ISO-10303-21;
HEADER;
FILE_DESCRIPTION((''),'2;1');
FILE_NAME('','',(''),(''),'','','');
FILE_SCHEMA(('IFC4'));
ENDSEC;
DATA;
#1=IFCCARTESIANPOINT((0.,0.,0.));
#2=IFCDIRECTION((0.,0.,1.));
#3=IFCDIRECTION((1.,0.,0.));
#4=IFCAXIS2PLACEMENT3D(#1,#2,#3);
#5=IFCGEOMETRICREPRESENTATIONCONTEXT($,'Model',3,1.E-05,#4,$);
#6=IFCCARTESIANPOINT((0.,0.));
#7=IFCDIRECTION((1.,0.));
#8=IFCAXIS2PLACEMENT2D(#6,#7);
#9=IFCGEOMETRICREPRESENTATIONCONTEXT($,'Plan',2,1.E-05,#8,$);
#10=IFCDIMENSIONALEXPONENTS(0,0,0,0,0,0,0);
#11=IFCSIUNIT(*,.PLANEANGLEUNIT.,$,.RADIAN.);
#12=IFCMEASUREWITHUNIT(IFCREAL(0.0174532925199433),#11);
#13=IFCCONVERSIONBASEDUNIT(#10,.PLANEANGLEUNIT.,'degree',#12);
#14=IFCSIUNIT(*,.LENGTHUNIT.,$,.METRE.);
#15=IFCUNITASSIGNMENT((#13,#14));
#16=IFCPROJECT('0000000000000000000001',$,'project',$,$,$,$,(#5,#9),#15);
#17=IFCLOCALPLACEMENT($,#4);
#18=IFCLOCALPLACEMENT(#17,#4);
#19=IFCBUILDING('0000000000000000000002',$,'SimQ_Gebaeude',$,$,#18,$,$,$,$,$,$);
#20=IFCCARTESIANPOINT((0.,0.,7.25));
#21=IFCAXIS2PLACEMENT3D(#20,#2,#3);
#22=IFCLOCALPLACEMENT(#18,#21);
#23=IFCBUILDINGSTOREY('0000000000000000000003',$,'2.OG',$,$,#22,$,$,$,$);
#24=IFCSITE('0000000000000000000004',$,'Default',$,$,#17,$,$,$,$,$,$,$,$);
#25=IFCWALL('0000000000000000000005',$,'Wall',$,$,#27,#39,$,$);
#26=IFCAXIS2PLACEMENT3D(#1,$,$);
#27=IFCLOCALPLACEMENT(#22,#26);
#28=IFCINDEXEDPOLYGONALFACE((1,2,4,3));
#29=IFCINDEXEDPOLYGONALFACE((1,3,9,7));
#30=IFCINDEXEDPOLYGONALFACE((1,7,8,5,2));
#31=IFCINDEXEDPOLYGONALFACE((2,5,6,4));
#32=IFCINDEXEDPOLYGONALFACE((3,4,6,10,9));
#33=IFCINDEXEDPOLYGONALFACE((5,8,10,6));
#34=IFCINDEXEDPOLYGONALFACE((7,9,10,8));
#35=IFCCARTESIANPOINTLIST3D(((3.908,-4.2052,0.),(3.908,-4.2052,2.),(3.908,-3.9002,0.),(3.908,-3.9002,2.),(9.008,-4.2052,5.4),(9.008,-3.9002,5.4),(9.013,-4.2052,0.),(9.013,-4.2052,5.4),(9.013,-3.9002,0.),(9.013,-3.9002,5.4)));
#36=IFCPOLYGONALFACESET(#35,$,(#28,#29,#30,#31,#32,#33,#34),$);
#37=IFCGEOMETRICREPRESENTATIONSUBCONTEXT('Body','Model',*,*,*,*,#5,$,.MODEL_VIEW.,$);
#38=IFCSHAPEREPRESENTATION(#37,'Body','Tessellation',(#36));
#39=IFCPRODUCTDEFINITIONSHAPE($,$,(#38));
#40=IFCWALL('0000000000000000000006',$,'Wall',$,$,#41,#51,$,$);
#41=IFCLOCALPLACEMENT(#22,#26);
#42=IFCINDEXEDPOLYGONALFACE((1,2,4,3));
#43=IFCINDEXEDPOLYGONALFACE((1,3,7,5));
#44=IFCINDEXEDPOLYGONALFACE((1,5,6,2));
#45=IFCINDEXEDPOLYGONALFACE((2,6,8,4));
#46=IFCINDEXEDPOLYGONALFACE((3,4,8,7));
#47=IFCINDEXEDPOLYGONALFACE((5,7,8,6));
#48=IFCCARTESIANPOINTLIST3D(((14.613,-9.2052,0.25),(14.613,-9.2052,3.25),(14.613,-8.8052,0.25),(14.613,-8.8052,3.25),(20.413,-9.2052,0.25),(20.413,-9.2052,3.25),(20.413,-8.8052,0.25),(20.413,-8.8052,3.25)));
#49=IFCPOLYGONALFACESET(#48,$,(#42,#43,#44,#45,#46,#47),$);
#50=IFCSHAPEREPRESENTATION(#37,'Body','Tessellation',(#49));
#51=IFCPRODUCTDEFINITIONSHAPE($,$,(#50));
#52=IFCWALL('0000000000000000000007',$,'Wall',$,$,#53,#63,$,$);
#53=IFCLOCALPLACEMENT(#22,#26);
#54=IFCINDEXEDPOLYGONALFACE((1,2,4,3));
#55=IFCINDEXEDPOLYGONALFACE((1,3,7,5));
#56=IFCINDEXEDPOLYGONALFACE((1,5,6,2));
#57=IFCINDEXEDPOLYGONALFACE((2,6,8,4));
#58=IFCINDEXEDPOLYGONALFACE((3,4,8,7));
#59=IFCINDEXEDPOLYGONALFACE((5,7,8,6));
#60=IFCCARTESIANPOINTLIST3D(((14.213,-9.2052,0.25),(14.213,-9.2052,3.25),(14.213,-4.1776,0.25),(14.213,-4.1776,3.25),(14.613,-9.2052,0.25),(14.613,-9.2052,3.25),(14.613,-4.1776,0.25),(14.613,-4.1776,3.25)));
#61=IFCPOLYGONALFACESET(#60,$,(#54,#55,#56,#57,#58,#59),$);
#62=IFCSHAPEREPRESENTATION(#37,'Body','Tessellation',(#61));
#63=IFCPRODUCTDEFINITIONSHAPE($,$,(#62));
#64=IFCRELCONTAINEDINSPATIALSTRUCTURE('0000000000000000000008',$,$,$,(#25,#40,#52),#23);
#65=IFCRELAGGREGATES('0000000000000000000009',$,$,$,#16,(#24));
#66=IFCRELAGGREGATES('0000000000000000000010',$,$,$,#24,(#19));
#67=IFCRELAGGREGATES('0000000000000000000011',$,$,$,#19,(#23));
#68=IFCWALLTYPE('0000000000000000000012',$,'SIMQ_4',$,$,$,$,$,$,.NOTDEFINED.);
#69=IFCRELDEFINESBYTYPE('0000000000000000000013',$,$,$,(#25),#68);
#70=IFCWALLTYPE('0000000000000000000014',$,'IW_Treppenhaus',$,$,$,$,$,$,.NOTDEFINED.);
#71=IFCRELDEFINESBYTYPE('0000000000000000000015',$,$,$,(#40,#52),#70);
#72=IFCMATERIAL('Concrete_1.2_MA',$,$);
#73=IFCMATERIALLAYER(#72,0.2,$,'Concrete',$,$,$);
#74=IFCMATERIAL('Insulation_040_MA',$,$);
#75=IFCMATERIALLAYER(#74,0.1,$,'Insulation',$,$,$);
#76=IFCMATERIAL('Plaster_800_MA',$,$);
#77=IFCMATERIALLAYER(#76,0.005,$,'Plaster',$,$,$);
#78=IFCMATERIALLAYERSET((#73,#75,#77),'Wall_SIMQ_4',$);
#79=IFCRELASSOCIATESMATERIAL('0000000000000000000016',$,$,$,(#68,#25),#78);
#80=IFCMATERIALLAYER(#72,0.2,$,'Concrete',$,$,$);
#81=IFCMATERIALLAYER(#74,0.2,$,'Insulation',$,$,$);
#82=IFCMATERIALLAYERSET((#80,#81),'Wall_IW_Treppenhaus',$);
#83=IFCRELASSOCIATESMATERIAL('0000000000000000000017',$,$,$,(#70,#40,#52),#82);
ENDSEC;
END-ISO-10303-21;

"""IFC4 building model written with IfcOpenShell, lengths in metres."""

from ifc_helpers import new_model, entity, si_unit, converted_unit, frame, origin_with_axes, origin_2d_with_axis, place, context, subcontext, project, spatial, indexed_curve, outline, extrude, clip, halfspace, material, layer, layer_set, layer_usage, type_object, element, save


model = new_model("IFC4")

# Units and contexts
model_context = context("Model", 3, precision=1e-05, world=origin_with_axes())
plan_context = context("Plan", 2, precision=1e-05, world=origin_2d_with_axis())
body_context = subcontext(model_context, "Body", "Model", "MODEL_VIEW")
ifc_project = project(units=[converted_unit("PLANEANGLEUNIT", "degree", entity("IfcReal", 0.0174532925199433), si_unit("PLANEANGLEUNIT", "RADIAN"), dimensions=[0, 0, 0, 0, 0, 0, 0]), si_unit("LENGTHUNIT", "METRE")], contexts=[model_context, plan_context])

# Site, building, storey
site_placement = place(None, origin_with_axes())
site = spatial("IfcSite", under=ifc_project, at=site_placement, Name="Default")
building_placement = place(site_placement, origin_with_axes())
building = spatial("IfcBuilding", under=site, at=building_placement, Name="SimQ_Gebaeude")
storey_placement = place(building_placement, frame((0.0, 0.0, 7.25), z_axis=(0.0, 0.0, 1.0), x_axis=(1.0, 0.0, 0.0)))
storey = spatial("IfcBuildingStorey", under=building, at=storey_placement, Name="2.OG")

# Shared definitions
ifc_material_1 = material(Name="Insulation_040_MA")
ifc_material_2 = material(Name="Concrete_1.2_MA")

# Shared definitions
ifc_layer_1 = layer(ifc_material_2, 0.2, Name="Concrete")
ifc_layer_2 = layer(ifc_material_1, 0.1, Name="Insulation")
ifc_material_3 = material(Name="Plaster_800_MA")
ifc_layer_3 = layer(ifc_material_3, 0.005, Name="Plaster")
ifc_layer_set_1 = layer_set([ifc_layer_1, ifc_layer_2, ifc_layer_3], Name="Wall_SIMQ_4")
wall_type_1 = type_object("IfcWallType", Name="SIMQ_4", PredefinedType="NOTDEFINED", material=ifc_layer_set_1)

# Walls
ifc_layer_usage_1 = layer_usage(ifc_layer_set_1, "AXIS2", "POSITIVE", 0.0)
wall_1_placement = place(storey_placement, frame((3.908, -4.2052, 0.0), z_axis=(0.0, 0.0, 1.0), x_axis=(1.0, 0.0, 0.0)))
element("IfcWall", 1, at=wall_1_placement, inside=storey, type_object=wall_type_1, material=ifc_layer_usage_1, Name="Wall", context=body_context, shape_type="Clipping", body=[
    clip(extrude(outline(indexed_curve([(0.0, 0.0), (0.0, 0.305), (5.105, 0.305), (5.105, 0.0), (0.0, 0.0)], self_intersect=False)), origin_with_axes(), (0.0, 0.0, 1.0), 5.4), halfspace(frame((0.5, 0.805, 2.3333), z_axis=(-0.554699, 0.0, 0.832051), x_axis=(0.832051, 0.0, 0.554699)), False)),
])
ifc_layer_4 = layer(ifc_material_2, 0.2, Name="Concrete")
ifc_layer_5 = layer(ifc_material_1, 0.2, Name="Insulation")
ifc_layer_set_2 = layer_set([ifc_layer_4, ifc_layer_5], Name="Wall_IW_Treppenhaus")
ifc_layer_usage_2 = layer_usage(ifc_layer_set_2, "AXIS2", "POSITIVE", 0.0)
wall_type_2 = type_object("IfcWallType", Name="IW_Treppenhaus", PredefinedType="NOTDEFINED", material=ifc_layer_set_2)
wall_2_placement = place(storey_placement, frame((20.413, -8.8052, 0.25), z_axis=(0.0, 0.0, 1.0), x_axis=(-1.0, 0.000001, 0.0)))
element("IfcWall", 2, at=wall_2_placement, inside=storey, type_object=wall_type_2, material=ifc_layer_usage_2, Name="Wall", context=body_context, shape_type="SweptSolid", body=[
    extrude(outline(indexed_curve([(0.0, 0.0), (0.0, 0.4), (5.8, 0.4), (5.8, 0.0), (0.0, 0.0)], self_intersect=False)), origin_with_axes(), (0.0, 0.0, 1.0), 3.0),
])
ifc_layer_usage_3 = layer_usage(ifc_layer_set_2, "AXIS2", "POSITIVE", 0.0)
wall_3_placement = place(storey_placement, frame((14.213, -4.1776, 0.25), z_axis=(0.0, 0.0, 1.0), x_axis=(-0.000001, -1.0, 0.0)))
element("IfcWall", 3, at=wall_3_placement, inside=storey, type_object=wall_type_2, material=ifc_layer_usage_3, Name="Wall", context=body_context, shape_type="SweptSolid", body=[
    extrude(outline(indexed_curve([(0.0, 0.0), (0.0, 0.4), (5.0276, 0.4), (5.0276, 0.0), (0.0, 0.0)], self_intersect=False)), origin_with_axes(), (0.0, 0.0, 1.0), 3.0),
])

save(model, "model.ifc")
